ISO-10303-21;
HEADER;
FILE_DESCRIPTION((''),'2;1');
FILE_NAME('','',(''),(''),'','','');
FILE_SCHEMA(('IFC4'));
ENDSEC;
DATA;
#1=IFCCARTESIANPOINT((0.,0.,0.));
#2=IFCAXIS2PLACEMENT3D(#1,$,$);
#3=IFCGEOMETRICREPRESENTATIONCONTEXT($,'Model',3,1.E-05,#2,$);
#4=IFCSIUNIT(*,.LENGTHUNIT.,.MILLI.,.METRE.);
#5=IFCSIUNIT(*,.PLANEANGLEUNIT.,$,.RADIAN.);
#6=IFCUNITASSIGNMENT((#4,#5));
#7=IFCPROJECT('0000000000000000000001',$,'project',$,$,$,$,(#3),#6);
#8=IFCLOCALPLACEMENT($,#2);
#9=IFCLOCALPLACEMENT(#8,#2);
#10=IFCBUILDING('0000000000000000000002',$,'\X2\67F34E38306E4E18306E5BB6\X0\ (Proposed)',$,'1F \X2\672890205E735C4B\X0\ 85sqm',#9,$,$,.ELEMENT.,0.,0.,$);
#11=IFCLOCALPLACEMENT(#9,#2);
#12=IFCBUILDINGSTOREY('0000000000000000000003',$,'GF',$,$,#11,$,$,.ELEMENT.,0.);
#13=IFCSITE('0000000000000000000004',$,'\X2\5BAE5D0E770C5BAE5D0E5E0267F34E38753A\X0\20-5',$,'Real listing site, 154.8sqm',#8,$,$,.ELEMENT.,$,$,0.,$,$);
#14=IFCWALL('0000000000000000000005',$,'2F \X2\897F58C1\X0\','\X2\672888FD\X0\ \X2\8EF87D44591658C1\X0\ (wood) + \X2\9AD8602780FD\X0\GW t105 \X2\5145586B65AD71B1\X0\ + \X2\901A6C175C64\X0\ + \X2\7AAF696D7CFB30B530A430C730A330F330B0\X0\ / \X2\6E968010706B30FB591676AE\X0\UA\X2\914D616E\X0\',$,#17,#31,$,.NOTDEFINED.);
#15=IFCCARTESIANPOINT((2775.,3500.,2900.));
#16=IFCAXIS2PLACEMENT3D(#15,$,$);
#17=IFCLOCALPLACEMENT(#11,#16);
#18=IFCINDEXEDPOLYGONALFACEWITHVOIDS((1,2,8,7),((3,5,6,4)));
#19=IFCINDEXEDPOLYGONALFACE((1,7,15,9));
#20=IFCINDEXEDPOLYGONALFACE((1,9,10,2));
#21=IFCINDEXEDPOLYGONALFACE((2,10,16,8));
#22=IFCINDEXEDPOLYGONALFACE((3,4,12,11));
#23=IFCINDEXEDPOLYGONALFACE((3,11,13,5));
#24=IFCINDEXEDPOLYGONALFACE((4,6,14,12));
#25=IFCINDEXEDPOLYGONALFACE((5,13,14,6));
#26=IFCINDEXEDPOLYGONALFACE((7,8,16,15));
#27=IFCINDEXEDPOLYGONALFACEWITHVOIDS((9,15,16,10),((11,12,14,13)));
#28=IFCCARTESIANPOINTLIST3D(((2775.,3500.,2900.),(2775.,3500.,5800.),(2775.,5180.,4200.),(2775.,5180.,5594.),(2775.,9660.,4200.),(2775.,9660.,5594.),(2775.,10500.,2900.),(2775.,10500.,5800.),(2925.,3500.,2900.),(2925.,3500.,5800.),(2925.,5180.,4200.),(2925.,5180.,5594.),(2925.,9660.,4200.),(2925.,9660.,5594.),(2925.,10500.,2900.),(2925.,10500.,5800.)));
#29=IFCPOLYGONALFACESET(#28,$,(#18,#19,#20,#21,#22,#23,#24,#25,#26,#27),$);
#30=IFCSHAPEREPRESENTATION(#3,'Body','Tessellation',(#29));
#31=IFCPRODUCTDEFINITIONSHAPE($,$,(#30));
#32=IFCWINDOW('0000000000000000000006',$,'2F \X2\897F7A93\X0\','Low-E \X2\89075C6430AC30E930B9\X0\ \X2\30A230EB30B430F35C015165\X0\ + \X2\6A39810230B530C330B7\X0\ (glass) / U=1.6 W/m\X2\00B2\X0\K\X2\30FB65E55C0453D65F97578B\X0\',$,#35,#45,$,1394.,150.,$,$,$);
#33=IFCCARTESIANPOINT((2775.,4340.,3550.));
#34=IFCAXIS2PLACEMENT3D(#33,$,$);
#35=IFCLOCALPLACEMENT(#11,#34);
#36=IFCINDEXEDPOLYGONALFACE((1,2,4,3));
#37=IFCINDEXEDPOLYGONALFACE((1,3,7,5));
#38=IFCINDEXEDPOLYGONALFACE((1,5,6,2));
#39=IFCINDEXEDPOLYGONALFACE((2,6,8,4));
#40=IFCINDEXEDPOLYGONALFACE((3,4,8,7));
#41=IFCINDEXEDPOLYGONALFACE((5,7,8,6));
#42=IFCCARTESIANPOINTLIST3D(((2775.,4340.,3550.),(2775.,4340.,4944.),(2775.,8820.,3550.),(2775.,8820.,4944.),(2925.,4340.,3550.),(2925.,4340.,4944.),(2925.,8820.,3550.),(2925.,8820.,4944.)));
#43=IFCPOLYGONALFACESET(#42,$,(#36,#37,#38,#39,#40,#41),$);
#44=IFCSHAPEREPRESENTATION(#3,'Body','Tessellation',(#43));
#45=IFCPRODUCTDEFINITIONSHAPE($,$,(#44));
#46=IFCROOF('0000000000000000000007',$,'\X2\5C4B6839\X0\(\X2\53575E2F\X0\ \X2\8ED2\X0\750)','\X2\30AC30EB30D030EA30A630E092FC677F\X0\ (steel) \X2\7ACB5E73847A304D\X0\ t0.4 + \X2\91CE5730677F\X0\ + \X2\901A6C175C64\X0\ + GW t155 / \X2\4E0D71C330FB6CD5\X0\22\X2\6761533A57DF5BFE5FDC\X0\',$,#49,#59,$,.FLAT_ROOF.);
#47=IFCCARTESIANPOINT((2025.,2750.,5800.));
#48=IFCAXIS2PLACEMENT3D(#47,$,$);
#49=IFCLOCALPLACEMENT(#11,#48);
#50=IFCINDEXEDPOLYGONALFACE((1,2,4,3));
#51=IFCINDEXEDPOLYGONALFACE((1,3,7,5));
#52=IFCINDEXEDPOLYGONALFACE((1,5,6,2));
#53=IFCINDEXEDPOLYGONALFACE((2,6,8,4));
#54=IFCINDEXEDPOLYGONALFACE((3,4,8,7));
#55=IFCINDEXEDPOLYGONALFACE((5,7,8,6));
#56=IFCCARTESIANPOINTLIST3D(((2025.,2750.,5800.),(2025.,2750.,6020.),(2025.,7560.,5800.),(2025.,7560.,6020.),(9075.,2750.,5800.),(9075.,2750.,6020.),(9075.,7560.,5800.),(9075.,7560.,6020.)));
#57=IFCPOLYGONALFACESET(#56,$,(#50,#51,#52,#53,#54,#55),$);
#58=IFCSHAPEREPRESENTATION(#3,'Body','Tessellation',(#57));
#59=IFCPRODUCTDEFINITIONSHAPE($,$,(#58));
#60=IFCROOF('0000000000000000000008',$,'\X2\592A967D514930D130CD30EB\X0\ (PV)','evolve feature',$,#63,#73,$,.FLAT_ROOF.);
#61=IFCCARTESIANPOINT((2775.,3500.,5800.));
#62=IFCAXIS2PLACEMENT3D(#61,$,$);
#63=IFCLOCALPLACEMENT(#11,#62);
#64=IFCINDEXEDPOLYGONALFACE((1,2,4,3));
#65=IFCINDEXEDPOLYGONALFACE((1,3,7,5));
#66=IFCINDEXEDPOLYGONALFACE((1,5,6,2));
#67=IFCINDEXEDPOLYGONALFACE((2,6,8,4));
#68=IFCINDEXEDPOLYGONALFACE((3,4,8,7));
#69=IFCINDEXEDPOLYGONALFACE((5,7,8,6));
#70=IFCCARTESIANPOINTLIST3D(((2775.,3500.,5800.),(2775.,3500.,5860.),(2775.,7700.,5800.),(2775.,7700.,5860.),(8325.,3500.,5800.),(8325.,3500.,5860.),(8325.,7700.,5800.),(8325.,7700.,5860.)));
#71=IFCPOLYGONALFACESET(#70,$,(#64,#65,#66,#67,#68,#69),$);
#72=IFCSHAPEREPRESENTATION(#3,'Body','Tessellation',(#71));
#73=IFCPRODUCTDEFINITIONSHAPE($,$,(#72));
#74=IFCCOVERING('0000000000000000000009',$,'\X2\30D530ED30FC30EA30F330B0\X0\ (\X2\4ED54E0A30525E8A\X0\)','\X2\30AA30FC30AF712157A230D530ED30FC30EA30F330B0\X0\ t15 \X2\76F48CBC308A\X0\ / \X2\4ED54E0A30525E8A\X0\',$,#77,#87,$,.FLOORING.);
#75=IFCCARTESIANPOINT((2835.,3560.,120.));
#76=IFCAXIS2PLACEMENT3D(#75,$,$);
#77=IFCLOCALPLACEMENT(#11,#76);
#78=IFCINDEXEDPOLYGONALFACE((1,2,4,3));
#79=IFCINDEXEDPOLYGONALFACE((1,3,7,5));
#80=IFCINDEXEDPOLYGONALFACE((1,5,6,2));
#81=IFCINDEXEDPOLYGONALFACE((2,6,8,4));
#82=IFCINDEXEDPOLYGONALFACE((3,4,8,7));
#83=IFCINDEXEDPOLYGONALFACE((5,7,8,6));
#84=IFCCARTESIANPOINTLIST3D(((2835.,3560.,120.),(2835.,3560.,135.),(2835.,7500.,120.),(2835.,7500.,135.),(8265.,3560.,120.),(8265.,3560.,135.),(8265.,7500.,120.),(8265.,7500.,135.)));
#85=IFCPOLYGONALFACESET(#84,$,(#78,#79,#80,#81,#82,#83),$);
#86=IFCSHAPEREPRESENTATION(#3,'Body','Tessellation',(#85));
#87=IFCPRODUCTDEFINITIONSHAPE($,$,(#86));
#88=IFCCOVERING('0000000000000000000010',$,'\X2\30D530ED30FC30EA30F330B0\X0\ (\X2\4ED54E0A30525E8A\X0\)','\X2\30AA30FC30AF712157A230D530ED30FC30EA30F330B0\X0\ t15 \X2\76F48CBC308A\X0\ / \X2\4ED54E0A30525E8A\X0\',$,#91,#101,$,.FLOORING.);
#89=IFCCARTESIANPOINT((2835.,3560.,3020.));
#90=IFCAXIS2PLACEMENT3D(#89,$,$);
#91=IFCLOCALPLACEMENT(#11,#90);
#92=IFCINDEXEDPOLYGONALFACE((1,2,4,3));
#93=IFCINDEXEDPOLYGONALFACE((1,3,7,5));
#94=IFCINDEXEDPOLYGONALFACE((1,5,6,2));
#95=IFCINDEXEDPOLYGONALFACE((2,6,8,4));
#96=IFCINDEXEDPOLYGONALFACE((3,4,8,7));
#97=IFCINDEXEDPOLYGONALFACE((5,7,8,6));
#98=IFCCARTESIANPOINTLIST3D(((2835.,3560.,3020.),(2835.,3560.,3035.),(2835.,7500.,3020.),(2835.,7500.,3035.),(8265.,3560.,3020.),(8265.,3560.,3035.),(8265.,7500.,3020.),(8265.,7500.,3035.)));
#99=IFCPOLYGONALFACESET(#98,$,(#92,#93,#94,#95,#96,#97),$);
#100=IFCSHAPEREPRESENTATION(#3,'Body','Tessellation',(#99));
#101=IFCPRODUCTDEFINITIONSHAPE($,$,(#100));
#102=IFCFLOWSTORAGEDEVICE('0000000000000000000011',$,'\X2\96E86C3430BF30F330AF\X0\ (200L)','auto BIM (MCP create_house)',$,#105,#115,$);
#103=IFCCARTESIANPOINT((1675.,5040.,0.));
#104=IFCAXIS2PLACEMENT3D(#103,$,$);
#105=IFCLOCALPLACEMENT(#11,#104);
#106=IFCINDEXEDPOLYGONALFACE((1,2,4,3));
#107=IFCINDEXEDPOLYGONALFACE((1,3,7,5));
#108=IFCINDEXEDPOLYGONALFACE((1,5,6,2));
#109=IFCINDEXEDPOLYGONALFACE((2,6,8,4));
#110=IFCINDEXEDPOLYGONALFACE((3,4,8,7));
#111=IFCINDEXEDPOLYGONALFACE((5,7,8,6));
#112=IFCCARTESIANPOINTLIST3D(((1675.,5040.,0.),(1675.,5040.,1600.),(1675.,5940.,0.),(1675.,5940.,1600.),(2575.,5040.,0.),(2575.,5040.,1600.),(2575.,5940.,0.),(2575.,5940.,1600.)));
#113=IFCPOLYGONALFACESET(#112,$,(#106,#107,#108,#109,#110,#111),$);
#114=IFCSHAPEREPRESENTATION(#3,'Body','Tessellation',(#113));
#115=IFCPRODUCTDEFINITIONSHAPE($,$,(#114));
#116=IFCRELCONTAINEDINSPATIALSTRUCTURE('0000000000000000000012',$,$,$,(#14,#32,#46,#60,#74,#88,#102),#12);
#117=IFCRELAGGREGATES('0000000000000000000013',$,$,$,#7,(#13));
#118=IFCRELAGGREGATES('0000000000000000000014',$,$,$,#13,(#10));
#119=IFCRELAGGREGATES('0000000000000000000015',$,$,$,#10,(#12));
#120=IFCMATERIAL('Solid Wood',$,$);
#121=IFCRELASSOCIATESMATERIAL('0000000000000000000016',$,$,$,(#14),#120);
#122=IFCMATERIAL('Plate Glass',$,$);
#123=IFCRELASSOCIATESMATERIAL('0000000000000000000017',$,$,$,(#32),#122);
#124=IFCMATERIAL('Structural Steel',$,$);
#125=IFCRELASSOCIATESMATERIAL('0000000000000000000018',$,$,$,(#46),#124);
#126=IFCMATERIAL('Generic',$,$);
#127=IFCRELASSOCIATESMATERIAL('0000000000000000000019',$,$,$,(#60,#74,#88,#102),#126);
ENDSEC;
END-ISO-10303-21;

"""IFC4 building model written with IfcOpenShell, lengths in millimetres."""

from ifc_helpers import new_model, si_unit, frame, frame_2d, origin, place, context, project, spatial, rectangle, extrude, material, element, fill, save


model = new_model("IFC4")

# Units and contexts
model_context = context("Model", 3, precision=1e-05, world=origin())
ifc_project = project(units=[si_unit("LENGTHUNIT", "METRE", prefix="MILLI"), si_unit("PLANEANGLEUNIT", "RADIAN")], contexts=[model_context])

# Site, building, storey
site_placement = place(None, origin())
site = spatial("IfcSite", under=ifc_project, at=site_placement, Name="宮崎県宮崎市柳丸町20-5", ObjectType="Real listing site, 154.8sqm", CompositionType="ELEMENT", RefElevation=0.0)
building_placement = place(site_placement, origin())
building = spatial("IfcBuilding", under=site, at=building_placement, Name="柳丸の丘の家 (Proposed)", ObjectType="1F 木造平屋 85sqm", CompositionType="ELEMENT", ElevationOfRefHeight=0.0, ElevationOfTerrain=0.0)
storey_placement = place(building_placement, origin())
storey = spatial("IfcBuildingStorey", under=building, at=storey_placement, Name="GF", CompositionType="ELEMENT", Elevation=0.0)

# Shared definitions
ifc_material_1 = material(Name="Solid Wood")
ifc_material_2 = material(Name="Generic")

# Shared definitions
ifc_material_3 = material(Name="Plate Glass")

# Wall, opening, window
wall_1_placement = place(storey_placement, frame((2775.0, 3500.0, 2900.0)))
wall_1 = element("IfcWall", 1, at=wall_1_placement, inside=storey, material=ifc_material_1, Name="2F 西壁", Description="木製 軸組外壁 (wood) + 高性能GW t105 充填断熱 + 通気層 + 窯業系サイディング / 準耐火・外皮UA配慮", PredefinedType="NOTDEFINED", context=model_context, shape_type="SweptSolid", body=[
    extrude(rectangle(XDim=150.0, YDim=7000.0, at=frame_2d((75.0, 3500.0))), frame((2775.0, 3500.0, 2900.0)), (0.0, 0.0, 1.0), 2900.0),
])
opening_1_placement = place(storey_placement, frame((2775.0, 4340.0, 3550.0)))
opening_1 = element("IfcOpeningElement", 2, at=opening_1_placement, cuts=wall_1, PredefinedType="NOTDEFINED", context=model_context, shape_type="SweptSolid", body=[
    extrude(rectangle(XDim=150.0, YDim=4480.0, at=frame_2d((75.0, 2240.0))), frame((2775.0, 4340.0, 3550.0)), (0.0, 0.0, 1.0), 1394.0),
])
window_1_placement = place(storey_placement, frame((2775.0, 4340.0, 3550.0)))
window_1 = element("IfcWindow", 3, at=window_1_placement, inside=storey, material=ifc_material_3, Name="2F 西窓", Description="Low-E 複層ガラス アルゴン封入 + 樹脂サッシ (glass) / U=1.6 W/m²K・日射取得型", OverallHeight=1394.0, OverallWidth=150.0, context=model_context, shape_type="SweptSolid", body=[
    extrude(rectangle(XDim=150.0, YDim=4480.0, at=frame_2d((75.0, 2240.0))), frame((2775.0, 4340.0, 3550.0)), (0.0, 0.0, 1.0), 1394.0),
])
fill(opening_1, window_1)

# Roofs
ifc_material_4 = material(Name="Structural Steel")
for number, where, name in (
    (4, (2025.0, 2750.0, 5800.0), "屋根(南帯 軒750)"),
):
    element("IfcRoof", number, at=place(storey_placement, frame(where)), inside=storey, material=ifc_material_4, Name=name, Description="ガルバリウム鋼板 (steel) 立平葺き t0.4 + 野地板 + 通気層 + GW t155 / 不燃・法22条区域対応", PredefinedType="FLAT_ROOF", context=model_context, shape_type="SweptSolid", body=[
        extrude(rectangle(XDim=7050.0, YDim=4810.0, at=frame_2d((3525.0, 2405.0))), frame((2025.0, 2750.0, 5800.0)), (0.0, 0.0, 1.0), 220.0),
    ])
roof_placement = place(storey_placement, frame((2775.0, 3500.0, 5800.0)))
element("IfcRoof", 5, at=roof_placement, inside=storey, material=ifc_material_2, Name="太陽光パネル (PV)", Description="evolve feature", PredefinedType="FLAT_ROOF", context=model_context, shape_type="SweptSolid", body=[
    extrude(rectangle(XDim=5550.0, YDim=4200.0, at=frame_2d((2775.0, 2100.0))), frame((2775.0, 3500.0, 5800.0)), (0.0, 0.0, 1.0), 60.0),
])

# Coverings
covering_1_placement = place(storey_placement, frame((2835.0, 3560.0, 120.0)))
element("IfcCovering", 6, at=covering_1_placement, inside=storey, material=ifc_material_2, Name="フローリング (仕上げ床)", Description="オーク無垢フローリング t15 直貼り / 仕上げ床", PredefinedType="FLOORING", context=model_context, shape_type="SweptSolid", body=[
    extrude(rectangle(XDim=5430.0, YDim=3940.0, at=frame_2d((2715.0, 1970.0))), frame((2835.0, 3560.0, 120.0)), (0.0, 0.0, 1.0), 15.0),
])
covering_2_placement = place(storey_placement, frame((2835.0, 3560.0, 3020.0)))
element("IfcCovering", 7, at=covering_2_placement, inside=storey, material=ifc_material_2, Name="フローリング (仕上げ床)", Description="オーク無垢フローリング t15 直貼り / 仕上げ床", PredefinedType="FLOORING", context=model_context, shape_type="SweptSolid", body=[
    extrude(rectangle(XDim=5430.0, YDim=3940.0, at=frame_2d((2715.0, 1970.0))), frame((2835.0, 3560.0, 3020.0)), (0.0, 0.0, 1.0), 15.0),
])

# Flow storage device
flow_storage_device_placement = place(storey_placement, frame((1675.0, 5040.0, 0.0)))
element("IfcFlowStorageDevice", 8, at=flow_storage_device_placement, inside=storey, material=ifc_material_2, Name="雨水タンク (200L)", Description="auto BIM (MCP create_house)", context=model_context, shape_type="SweptSolid", body=[
    extrude(rectangle(XDim=900.0, YDim=900.0, at=frame_2d((450.0, 450.0))), frame((1675.0, 5040.0, 0.0)), (0.0, 0.0, 1.0), 1600.0),
])

save(model, "model.ifc")
